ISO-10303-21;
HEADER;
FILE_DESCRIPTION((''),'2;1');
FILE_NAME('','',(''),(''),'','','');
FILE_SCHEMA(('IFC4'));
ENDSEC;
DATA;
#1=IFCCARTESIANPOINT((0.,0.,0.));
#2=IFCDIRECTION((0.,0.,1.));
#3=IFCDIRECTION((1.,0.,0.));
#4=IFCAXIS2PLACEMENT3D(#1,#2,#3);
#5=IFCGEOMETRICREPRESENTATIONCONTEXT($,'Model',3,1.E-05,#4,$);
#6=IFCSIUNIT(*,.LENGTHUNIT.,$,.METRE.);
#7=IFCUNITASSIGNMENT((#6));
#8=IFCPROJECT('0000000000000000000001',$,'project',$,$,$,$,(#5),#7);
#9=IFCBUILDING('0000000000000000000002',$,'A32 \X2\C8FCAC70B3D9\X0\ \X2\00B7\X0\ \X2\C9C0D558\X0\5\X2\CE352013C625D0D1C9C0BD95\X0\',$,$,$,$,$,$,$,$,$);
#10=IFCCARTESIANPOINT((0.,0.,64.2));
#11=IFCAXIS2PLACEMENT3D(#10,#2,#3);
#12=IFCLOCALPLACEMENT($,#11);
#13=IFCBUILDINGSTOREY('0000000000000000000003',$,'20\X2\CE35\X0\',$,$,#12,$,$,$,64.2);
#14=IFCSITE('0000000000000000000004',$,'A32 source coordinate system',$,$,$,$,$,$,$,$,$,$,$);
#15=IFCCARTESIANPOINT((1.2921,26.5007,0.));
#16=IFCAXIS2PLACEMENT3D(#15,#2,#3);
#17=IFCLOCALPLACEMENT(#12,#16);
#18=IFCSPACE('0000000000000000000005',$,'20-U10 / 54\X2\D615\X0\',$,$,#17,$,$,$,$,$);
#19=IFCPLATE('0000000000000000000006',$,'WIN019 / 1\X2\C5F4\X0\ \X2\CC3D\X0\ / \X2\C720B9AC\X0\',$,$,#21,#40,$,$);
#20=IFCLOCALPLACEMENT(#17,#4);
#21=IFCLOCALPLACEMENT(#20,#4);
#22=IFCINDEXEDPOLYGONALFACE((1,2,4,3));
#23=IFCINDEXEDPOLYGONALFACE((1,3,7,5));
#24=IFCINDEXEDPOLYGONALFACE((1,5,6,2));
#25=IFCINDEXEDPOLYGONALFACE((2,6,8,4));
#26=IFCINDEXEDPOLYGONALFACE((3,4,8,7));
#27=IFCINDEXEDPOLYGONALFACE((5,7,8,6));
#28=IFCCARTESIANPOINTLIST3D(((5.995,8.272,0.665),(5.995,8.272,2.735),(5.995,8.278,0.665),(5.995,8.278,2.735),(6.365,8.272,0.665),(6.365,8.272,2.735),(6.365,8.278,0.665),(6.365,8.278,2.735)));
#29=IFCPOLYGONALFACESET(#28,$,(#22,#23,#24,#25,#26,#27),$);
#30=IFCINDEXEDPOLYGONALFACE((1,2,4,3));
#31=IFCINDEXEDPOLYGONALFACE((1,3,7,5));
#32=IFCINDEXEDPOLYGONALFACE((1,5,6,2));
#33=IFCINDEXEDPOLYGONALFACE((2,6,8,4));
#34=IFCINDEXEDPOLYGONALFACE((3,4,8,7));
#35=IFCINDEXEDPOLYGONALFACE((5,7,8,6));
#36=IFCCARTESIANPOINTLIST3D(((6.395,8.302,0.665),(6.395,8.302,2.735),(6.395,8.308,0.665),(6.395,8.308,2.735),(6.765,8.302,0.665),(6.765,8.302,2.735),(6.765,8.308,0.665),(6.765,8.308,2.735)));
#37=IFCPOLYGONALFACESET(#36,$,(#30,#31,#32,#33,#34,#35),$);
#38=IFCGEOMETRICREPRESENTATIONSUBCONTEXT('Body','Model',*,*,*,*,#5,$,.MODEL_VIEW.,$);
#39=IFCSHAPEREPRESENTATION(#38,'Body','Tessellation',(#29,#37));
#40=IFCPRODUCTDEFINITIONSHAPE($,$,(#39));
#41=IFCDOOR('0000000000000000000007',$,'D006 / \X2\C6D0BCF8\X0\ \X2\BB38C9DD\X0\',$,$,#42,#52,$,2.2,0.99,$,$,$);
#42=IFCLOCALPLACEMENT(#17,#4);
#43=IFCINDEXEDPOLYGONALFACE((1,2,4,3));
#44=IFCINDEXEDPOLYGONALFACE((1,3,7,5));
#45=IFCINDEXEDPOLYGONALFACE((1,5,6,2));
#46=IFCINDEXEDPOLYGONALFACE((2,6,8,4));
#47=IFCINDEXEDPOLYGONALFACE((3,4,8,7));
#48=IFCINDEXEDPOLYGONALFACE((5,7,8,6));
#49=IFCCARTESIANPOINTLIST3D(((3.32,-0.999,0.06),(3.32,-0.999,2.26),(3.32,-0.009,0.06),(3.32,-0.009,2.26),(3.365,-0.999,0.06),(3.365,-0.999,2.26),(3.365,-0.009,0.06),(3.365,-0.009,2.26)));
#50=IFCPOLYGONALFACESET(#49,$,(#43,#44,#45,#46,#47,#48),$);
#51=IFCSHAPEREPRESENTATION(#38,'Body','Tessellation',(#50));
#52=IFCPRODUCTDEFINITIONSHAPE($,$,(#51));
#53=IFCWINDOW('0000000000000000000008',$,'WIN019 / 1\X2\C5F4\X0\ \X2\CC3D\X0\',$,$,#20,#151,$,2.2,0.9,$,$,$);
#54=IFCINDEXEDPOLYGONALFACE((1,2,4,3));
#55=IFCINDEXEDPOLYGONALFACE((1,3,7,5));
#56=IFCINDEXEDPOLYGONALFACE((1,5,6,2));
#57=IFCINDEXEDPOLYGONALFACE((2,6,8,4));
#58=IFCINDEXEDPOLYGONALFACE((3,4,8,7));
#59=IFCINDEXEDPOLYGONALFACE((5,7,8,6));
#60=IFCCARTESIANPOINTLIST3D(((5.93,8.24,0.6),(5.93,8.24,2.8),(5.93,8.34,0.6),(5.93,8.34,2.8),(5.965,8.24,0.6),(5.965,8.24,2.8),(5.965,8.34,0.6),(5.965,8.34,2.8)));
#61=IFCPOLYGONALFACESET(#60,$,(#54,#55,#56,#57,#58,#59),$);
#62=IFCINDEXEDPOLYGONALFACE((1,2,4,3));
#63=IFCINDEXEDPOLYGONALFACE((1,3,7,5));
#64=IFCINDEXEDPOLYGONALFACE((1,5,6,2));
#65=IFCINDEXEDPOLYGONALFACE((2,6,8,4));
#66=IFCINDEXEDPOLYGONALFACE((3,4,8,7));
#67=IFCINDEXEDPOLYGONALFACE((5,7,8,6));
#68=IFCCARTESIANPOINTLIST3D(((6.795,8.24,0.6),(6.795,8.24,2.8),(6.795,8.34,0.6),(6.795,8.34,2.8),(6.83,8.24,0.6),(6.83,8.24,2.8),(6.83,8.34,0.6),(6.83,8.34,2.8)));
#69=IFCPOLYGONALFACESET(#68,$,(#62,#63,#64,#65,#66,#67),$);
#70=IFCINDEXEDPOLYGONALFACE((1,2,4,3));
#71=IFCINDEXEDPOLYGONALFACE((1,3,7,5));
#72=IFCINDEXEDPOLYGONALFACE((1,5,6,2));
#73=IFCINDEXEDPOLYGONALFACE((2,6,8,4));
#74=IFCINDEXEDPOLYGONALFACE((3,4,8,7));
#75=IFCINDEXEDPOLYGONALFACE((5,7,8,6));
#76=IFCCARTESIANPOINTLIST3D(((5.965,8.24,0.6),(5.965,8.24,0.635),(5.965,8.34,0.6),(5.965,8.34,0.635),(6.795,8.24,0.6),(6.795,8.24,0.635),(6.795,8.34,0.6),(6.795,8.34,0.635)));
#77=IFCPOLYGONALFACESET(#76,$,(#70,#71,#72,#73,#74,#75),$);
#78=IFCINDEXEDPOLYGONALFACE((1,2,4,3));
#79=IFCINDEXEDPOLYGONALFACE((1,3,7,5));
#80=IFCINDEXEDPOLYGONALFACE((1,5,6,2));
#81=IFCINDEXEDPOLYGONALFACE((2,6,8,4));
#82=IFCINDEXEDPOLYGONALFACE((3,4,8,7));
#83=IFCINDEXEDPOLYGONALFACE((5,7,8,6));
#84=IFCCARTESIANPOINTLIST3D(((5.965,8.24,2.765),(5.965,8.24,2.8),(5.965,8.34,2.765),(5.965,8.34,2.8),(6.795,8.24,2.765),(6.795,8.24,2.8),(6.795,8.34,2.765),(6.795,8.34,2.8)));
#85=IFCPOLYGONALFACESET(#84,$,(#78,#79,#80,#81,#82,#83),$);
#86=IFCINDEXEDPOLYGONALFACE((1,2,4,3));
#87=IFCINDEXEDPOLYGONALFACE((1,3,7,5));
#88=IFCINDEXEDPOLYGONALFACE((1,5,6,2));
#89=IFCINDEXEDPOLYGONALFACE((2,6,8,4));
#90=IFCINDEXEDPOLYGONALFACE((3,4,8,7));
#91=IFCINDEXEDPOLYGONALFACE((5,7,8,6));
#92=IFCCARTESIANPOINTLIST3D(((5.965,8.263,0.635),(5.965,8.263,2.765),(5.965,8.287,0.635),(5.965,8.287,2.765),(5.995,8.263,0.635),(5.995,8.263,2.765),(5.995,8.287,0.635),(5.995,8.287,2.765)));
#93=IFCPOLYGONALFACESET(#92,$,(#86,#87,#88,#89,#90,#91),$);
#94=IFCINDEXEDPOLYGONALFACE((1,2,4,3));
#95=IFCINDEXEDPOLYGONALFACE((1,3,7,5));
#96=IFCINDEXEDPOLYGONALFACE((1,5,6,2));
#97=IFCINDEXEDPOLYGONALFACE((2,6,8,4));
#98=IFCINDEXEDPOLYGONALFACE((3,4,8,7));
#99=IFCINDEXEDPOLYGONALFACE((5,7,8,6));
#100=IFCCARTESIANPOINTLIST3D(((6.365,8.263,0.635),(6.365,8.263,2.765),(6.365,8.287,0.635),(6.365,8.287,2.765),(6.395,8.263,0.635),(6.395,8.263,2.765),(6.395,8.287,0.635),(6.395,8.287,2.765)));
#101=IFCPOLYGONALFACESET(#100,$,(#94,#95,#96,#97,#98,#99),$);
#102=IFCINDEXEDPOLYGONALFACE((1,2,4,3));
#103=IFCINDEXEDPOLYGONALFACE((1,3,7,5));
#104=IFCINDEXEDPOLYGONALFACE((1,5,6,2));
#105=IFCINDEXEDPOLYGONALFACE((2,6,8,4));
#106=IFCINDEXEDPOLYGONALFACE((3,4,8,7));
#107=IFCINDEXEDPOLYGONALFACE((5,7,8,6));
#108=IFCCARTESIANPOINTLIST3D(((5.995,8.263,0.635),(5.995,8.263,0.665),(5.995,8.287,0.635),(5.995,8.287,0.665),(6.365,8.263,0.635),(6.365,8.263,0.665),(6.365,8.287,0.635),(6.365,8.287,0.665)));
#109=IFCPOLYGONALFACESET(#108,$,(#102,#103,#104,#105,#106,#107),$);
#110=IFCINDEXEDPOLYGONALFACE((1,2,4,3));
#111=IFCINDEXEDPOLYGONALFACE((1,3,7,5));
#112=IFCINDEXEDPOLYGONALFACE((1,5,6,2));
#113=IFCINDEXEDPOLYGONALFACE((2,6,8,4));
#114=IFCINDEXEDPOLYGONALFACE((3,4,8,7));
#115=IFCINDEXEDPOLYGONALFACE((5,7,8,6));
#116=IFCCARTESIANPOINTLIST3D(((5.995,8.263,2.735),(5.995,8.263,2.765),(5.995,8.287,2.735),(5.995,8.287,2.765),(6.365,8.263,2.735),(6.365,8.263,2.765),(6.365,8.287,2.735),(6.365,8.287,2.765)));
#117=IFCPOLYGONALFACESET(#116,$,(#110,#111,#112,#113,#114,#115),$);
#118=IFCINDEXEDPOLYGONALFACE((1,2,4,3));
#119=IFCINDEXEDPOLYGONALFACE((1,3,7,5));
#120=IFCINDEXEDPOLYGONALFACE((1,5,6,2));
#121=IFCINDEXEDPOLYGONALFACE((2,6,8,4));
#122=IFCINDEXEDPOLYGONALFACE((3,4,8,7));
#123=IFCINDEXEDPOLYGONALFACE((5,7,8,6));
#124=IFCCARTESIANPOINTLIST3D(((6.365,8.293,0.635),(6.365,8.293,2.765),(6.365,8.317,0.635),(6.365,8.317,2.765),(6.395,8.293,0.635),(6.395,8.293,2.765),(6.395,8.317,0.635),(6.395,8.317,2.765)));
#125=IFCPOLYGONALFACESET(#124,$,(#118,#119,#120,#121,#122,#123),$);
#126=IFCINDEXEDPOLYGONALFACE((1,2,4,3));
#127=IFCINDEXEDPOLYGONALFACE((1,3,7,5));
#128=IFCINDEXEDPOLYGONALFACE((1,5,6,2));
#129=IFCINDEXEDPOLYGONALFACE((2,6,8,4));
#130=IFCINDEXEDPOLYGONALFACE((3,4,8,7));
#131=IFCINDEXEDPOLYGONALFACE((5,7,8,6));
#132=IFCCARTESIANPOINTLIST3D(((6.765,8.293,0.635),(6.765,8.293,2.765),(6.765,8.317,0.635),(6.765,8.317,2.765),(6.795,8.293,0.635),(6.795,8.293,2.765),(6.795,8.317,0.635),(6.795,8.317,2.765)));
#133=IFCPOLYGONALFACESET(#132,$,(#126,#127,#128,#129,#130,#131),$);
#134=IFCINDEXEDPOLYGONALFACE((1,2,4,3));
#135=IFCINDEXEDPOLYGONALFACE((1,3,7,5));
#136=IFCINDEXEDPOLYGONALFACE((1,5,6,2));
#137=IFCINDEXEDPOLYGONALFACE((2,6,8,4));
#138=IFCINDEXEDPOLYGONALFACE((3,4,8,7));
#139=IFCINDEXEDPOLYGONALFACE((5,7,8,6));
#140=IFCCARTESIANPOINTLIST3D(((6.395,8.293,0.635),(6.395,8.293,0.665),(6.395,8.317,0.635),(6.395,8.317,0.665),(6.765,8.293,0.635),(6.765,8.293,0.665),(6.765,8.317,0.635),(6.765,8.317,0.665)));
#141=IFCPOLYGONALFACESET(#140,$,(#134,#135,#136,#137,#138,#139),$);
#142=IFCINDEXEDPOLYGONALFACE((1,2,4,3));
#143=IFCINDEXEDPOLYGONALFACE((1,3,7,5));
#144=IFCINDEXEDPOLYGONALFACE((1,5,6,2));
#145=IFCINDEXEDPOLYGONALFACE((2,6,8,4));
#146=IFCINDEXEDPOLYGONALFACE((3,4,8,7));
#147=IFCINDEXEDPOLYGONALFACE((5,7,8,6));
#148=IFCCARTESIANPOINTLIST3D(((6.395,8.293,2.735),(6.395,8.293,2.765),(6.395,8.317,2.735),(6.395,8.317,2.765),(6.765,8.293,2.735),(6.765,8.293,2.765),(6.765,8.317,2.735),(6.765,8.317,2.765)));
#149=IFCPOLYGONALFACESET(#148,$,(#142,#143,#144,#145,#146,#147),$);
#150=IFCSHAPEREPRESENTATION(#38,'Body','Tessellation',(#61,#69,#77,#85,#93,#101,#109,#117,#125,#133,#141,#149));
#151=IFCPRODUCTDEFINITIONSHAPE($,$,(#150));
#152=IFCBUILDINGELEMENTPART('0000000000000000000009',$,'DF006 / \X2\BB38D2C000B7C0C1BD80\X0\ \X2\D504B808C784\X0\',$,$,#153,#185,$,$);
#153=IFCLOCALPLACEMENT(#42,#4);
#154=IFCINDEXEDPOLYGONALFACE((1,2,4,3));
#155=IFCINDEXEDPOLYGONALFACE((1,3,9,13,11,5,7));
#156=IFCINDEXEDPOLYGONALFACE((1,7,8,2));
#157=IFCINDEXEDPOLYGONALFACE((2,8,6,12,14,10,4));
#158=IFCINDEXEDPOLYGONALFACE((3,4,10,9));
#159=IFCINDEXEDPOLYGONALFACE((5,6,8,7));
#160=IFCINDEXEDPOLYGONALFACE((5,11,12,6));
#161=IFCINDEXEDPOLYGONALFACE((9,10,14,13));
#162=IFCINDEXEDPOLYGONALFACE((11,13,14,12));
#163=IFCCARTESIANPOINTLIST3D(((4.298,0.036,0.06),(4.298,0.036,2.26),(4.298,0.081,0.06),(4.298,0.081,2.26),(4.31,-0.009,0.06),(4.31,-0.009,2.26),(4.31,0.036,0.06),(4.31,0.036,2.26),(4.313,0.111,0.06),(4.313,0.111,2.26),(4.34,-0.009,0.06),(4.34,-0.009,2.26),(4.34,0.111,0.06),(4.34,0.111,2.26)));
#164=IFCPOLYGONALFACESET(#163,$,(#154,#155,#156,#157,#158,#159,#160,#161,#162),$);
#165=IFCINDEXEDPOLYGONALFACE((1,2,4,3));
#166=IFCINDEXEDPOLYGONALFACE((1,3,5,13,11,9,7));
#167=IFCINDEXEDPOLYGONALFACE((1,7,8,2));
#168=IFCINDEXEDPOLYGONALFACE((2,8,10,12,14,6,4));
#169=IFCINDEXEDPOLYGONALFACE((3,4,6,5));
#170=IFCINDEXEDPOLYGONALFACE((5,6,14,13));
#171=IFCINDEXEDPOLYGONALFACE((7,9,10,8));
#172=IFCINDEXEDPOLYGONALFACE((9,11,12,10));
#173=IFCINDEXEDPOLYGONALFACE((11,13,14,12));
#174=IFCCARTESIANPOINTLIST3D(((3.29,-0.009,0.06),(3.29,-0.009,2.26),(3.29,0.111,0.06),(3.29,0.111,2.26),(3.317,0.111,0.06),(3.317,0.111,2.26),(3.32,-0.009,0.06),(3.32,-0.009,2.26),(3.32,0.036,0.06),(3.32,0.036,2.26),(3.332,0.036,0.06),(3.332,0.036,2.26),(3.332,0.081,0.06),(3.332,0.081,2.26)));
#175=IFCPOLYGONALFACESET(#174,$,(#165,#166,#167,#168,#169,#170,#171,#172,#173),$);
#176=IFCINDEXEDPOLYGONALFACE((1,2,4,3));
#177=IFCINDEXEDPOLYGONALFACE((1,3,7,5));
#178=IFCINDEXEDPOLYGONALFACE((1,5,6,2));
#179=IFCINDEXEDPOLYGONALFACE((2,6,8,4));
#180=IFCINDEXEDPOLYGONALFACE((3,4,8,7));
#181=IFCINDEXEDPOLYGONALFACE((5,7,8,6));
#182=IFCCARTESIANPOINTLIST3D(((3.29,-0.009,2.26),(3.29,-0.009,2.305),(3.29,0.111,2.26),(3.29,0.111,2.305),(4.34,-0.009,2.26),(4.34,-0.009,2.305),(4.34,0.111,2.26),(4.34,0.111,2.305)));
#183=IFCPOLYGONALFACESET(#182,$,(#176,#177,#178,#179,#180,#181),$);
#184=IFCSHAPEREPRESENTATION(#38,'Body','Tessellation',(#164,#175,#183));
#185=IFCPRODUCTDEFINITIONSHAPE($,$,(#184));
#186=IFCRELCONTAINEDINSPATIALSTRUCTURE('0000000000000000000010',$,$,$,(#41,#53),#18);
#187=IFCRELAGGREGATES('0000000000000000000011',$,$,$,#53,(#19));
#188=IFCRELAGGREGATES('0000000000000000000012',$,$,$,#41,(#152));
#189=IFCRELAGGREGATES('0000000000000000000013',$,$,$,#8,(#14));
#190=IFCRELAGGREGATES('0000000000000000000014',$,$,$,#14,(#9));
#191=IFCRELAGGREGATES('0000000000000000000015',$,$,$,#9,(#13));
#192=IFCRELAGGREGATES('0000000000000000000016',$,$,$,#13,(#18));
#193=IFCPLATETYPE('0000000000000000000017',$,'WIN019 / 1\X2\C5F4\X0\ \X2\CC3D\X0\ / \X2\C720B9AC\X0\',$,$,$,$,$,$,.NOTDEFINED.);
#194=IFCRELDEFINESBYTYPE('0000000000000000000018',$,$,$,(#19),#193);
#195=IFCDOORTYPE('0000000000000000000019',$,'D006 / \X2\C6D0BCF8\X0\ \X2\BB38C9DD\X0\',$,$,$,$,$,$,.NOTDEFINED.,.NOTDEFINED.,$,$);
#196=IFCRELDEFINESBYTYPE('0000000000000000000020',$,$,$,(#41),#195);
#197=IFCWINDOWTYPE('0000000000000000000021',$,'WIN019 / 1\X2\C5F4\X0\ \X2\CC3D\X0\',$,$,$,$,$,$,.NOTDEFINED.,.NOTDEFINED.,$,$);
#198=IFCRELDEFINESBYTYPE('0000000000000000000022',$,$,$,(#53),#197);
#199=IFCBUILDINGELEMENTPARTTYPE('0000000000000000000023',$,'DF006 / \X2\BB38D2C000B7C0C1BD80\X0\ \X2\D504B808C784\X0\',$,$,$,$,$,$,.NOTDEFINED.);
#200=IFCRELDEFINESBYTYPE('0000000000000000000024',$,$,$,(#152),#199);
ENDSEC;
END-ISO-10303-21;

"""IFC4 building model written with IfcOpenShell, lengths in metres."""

from ifc_helpers import new_model, si_unit, frame, origin, origin_with_axes, place, context, subcontext, project, spatial, polyline, outline, extrude, source, transform, mapped, type_object, type_shapes, element, aggregate, save


model = new_model("IFC4")

# Units and contexts
model_context = context("Model", 3, precision=1e-05, world=origin_with_axes())
body_context = subcontext(model_context, "Body", "Model", "MODEL_VIEW")
ifc_project = project(units=[si_unit("LENGTHUNIT", "METRE")], contexts=[model_context])

# Plate
storey_placement = place(None, frame((0.0, 0.0, 64.2), z_axis=(0.0, 0.0, 1.0), x_axis=(1.0, 0.0, 0.0)))
space_placement = place(storey_placement, frame((1.2921, 26.5007, 0.0), z_axis=(0.0, 0.0, 1.0), x_axis=(1.0, 0.0, 0.0)))
plate_type_1 = type_object("IfcPlateType", Name="WIN019 / 1열 창 / 유리", PredefinedType="NOTDEFINED")
shared_shape_1 = source(origin(), body_context, "Body", "SweptSolid", [
    extrude(outline(polyline([(5.995, 8.272), (5.995, 8.278), (6.365, 8.278), (6.365, 8.272), (5.995, 8.272)])), frame((0.0, 0.0, 0.665)), (0.0, 0.0, 1.0), 2.07),
    extrude(outline(polyline([(6.395, 8.302), (6.395, 8.308), (6.765, 8.308), (6.765, 8.302), (6.395, 8.302)])), frame((0.0, 0.0, 0.665)), (0.0, 0.0, 1.0), 2.07),
])
type_shapes(plate_type_1, [shared_shape_1])
window_1_placement = place(space_placement, origin_with_axes())
plate_1_placement = place(window_1_placement, origin_with_axes())
plate_1 = element("IfcPlate", 1, at=plate_1_placement, type_object=plate_type_1, Name="WIN019 / 1열 창 / 유리", context=body_context, shape_type="MappedRepresentation", body=[
    mapped(shared_shape_1, transform((0.0, 0.0, 0.0), scale=1.0)),
])

# Site, building, storey, space
site = spatial("IfcSite", under=ifc_project, Name="A32 source coordinate system")
building = spatial("IfcBuilding", under=site, Name="A32 주거동 · 지하5층–옥탑지붕")
storey = spatial("IfcBuildingStorey", under=building, at=storey_placement, Name="20층", Elevation=64.2)
space = spatial("IfcSpace", under=storey, at=space_placement, Name="20-U10 / 54형")

# Door
door_type_1 = type_object("IfcDoorType", Name="D006 / 원본 문짝", OperationType="NOTDEFINED", PredefinedType="NOTDEFINED")
shared_shape_2 = source(origin(), body_context, "Body", "SweptSolid", [
    extrude(outline(polyline([(3.365, -0.999), (3.32, -0.999), (3.32, -0.009), (3.365, -0.009), (3.365, -0.999)])), frame((0.0, 0.0, 0.06)), (0.0, 0.0, 1.0), 2.2),
])
type_shapes(door_type_1, [shared_shape_2])
door_1_placement = place(space_placement, origin_with_axes())
door_1 = element("IfcDoor", 2, at=door_1_placement, inside=space, type_object=door_type_1, Name="D006 / 원본 문짝", OverallHeight=2.2, OverallWidth=0.99, context=body_context, shape_type="MappedRepresentation", body=[
    mapped(shared_shape_2, transform((0.0, 0.0, 0.0), scale=1.0)),
])

# Window
window_type_1 = type_object("IfcWindowType", Name="WIN019 / 1열 창", PartitioningType="NOTDEFINED", PredefinedType="NOTDEFINED")
shared_shape_3 = source(origin(), body_context, "Body", "SweptSolid", [
    extrude(outline(polyline([(5.93, 8.24), (5.93, 8.34), (5.965, 8.34), (5.965, 8.24), (5.93, 8.24)])), frame((0.0, 0.0, 0.6)), (0.0, 0.0, 1.0), 2.2),
    extrude(outline(polyline([(6.795, 8.24), (6.795, 8.34), (6.83, 8.34), (6.83, 8.24), (6.795, 8.24)])), frame((0.0, 0.0, 0.6)), (0.0, 0.0, 1.0), 2.2),
    extrude(outline(polyline([(5.965, 8.24), (5.965, 8.34), (6.795, 8.34), (6.795, 8.24), (5.965, 8.24)])), frame((0.0, 0.0, 0.6)), (0.0, 0.0, 1.0), 0.035),
    extrude(outline(polyline([(5.965, 8.24), (5.965, 8.34), (6.795, 8.34), (6.795, 8.24), (5.965, 8.24)])), frame((0.0, 0.0, 2.765)), (0.0, 0.0, 1.0), 0.035),
    extrude(outline(polyline([(5.965, 8.263), (5.965, 8.287), (5.995, 8.287), (5.995, 8.263), (5.965, 8.263)])), frame((0.0, 0.0, 0.635)), (0.0, 0.0, 1.0), 2.13),
    extrude(outline(polyline([(6.365, 8.263), (6.365, 8.287), (6.395, 8.287), (6.395, 8.263), (6.365, 8.263)])), frame((0.0, 0.0, 0.635)), (0.0, 0.0, 1.0), 2.13),
    extrude(outline(polyline([(5.995, 8.263), (5.995, 8.287), (6.365, 8.287), (6.365, 8.263), (5.995, 8.263)])), frame((0.0, 0.0, 0.635)), (0.0, 0.0, 1.0), 0.03),
    extrude(outline(polyline([(5.995, 8.263), (5.995, 8.287), (6.365, 8.287), (6.365, 8.263), (5.995, 8.263)])), frame((0.0, 0.0, 2.735)), (0.0, 0.0, 1.0), 0.03),
    extrude(outline(polyline([(6.365, 8.293), (6.365, 8.317), (6.395, 8.317), (6.395, 8.293), (6.365, 8.293)])), frame((0.0, 0.0, 0.635)), (0.0, 0.0, 1.0), 2.13),
    extrude(outline(polyline([(6.765, 8.293), (6.765, 8.317), (6.795, 8.317), (6.795, 8.293), (6.765, 8.293)])), frame((0.0, 0.0, 0.635)), (0.0, 0.0, 1.0), 2.13),
    extrude(outline(polyline([(6.395, 8.293), (6.395, 8.317), (6.765, 8.317), (6.765, 8.293), (6.395, 8.293)])), frame((0.0, 0.0, 0.635)), (0.0, 0.0, 1.0), 0.03),
    extrude(outline(polyline([(6.395, 8.293), (6.395, 8.317), (6.765, 8.317), (6.765, 8.293), (6.395, 8.293)])), frame((0.0, 0.0, 2.735)), (0.0, 0.0, 1.0), 0.03),
])
type_shapes(window_type_1, [shared_shape_3])
window_1 = element("IfcWindow", 3, at=window_1_placement, inside=space, type_object=window_type_1, Name="WIN019 / 1열 창", OverallHeight=2.2, OverallWidth=0.9, context=body_context, shape_type="MappedRepresentation", body=[
    mapped(shared_shape_3, transform((0.0, 0.0, 0.0), scale=1.0)),
])
aggregate(window_1, [plate_1])

# Building element part
building_element_part_type_1 = type_object("IfcBuildingElementPartType", Name="DF006 / 문틀·상부 프레임", PredefinedType="NOTDEFINED")
shared_shape_4 = source(origin(), body_context, "Body", "SweptSolid", [
    extrude(outline(polyline([(4.31, -0.009), (4.31, 0.036), (4.298, 0.036), (4.298, 0.081), (4.313, 0.111), (4.34, 0.111), (4.34, -0.009), (4.31, -0.009)])), frame((0.0, 0.0, 0.06)), (0.0, 0.0, 1.0), 2.2),
    extrude(outline(polyline([(3.29, 0.111), (3.317, 0.111), (3.332, 0.081), (3.332, 0.036), (3.32, 0.036), (3.32, -0.009), (3.29, -0.009), (3.29, 0.111)])), frame((0.0, 0.0, 0.06)), (0.0, 0.0, 1.0), 2.2),
    extrude(outline(polyline([(3.29, -0.009), (3.29, 0.111), (4.34, 0.111), (4.34, -0.009), (3.29, -0.009)])), frame((0.0, 0.0, 2.26)), (0.0, 0.0, 1.0), 0.045),
])
type_shapes(building_element_part_type_1, [shared_shape_4])
building_element_part_1_placement = place(door_1_placement, origin_with_axes())
building_element_part_1 = element("IfcBuildingElementPart", 4, at=building_element_part_1_placement, type_object=building_element_part_type_1, Name="DF006 / 문틀·상부 프레임", context=body_context, shape_type="MappedRepresentation", body=[
    mapped(shared_shape_4, transform((0.0, 0.0, 0.0), scale=1.0)),
])
aggregate(door_1, [building_element_part_1])

save(model, "model.ifc")
